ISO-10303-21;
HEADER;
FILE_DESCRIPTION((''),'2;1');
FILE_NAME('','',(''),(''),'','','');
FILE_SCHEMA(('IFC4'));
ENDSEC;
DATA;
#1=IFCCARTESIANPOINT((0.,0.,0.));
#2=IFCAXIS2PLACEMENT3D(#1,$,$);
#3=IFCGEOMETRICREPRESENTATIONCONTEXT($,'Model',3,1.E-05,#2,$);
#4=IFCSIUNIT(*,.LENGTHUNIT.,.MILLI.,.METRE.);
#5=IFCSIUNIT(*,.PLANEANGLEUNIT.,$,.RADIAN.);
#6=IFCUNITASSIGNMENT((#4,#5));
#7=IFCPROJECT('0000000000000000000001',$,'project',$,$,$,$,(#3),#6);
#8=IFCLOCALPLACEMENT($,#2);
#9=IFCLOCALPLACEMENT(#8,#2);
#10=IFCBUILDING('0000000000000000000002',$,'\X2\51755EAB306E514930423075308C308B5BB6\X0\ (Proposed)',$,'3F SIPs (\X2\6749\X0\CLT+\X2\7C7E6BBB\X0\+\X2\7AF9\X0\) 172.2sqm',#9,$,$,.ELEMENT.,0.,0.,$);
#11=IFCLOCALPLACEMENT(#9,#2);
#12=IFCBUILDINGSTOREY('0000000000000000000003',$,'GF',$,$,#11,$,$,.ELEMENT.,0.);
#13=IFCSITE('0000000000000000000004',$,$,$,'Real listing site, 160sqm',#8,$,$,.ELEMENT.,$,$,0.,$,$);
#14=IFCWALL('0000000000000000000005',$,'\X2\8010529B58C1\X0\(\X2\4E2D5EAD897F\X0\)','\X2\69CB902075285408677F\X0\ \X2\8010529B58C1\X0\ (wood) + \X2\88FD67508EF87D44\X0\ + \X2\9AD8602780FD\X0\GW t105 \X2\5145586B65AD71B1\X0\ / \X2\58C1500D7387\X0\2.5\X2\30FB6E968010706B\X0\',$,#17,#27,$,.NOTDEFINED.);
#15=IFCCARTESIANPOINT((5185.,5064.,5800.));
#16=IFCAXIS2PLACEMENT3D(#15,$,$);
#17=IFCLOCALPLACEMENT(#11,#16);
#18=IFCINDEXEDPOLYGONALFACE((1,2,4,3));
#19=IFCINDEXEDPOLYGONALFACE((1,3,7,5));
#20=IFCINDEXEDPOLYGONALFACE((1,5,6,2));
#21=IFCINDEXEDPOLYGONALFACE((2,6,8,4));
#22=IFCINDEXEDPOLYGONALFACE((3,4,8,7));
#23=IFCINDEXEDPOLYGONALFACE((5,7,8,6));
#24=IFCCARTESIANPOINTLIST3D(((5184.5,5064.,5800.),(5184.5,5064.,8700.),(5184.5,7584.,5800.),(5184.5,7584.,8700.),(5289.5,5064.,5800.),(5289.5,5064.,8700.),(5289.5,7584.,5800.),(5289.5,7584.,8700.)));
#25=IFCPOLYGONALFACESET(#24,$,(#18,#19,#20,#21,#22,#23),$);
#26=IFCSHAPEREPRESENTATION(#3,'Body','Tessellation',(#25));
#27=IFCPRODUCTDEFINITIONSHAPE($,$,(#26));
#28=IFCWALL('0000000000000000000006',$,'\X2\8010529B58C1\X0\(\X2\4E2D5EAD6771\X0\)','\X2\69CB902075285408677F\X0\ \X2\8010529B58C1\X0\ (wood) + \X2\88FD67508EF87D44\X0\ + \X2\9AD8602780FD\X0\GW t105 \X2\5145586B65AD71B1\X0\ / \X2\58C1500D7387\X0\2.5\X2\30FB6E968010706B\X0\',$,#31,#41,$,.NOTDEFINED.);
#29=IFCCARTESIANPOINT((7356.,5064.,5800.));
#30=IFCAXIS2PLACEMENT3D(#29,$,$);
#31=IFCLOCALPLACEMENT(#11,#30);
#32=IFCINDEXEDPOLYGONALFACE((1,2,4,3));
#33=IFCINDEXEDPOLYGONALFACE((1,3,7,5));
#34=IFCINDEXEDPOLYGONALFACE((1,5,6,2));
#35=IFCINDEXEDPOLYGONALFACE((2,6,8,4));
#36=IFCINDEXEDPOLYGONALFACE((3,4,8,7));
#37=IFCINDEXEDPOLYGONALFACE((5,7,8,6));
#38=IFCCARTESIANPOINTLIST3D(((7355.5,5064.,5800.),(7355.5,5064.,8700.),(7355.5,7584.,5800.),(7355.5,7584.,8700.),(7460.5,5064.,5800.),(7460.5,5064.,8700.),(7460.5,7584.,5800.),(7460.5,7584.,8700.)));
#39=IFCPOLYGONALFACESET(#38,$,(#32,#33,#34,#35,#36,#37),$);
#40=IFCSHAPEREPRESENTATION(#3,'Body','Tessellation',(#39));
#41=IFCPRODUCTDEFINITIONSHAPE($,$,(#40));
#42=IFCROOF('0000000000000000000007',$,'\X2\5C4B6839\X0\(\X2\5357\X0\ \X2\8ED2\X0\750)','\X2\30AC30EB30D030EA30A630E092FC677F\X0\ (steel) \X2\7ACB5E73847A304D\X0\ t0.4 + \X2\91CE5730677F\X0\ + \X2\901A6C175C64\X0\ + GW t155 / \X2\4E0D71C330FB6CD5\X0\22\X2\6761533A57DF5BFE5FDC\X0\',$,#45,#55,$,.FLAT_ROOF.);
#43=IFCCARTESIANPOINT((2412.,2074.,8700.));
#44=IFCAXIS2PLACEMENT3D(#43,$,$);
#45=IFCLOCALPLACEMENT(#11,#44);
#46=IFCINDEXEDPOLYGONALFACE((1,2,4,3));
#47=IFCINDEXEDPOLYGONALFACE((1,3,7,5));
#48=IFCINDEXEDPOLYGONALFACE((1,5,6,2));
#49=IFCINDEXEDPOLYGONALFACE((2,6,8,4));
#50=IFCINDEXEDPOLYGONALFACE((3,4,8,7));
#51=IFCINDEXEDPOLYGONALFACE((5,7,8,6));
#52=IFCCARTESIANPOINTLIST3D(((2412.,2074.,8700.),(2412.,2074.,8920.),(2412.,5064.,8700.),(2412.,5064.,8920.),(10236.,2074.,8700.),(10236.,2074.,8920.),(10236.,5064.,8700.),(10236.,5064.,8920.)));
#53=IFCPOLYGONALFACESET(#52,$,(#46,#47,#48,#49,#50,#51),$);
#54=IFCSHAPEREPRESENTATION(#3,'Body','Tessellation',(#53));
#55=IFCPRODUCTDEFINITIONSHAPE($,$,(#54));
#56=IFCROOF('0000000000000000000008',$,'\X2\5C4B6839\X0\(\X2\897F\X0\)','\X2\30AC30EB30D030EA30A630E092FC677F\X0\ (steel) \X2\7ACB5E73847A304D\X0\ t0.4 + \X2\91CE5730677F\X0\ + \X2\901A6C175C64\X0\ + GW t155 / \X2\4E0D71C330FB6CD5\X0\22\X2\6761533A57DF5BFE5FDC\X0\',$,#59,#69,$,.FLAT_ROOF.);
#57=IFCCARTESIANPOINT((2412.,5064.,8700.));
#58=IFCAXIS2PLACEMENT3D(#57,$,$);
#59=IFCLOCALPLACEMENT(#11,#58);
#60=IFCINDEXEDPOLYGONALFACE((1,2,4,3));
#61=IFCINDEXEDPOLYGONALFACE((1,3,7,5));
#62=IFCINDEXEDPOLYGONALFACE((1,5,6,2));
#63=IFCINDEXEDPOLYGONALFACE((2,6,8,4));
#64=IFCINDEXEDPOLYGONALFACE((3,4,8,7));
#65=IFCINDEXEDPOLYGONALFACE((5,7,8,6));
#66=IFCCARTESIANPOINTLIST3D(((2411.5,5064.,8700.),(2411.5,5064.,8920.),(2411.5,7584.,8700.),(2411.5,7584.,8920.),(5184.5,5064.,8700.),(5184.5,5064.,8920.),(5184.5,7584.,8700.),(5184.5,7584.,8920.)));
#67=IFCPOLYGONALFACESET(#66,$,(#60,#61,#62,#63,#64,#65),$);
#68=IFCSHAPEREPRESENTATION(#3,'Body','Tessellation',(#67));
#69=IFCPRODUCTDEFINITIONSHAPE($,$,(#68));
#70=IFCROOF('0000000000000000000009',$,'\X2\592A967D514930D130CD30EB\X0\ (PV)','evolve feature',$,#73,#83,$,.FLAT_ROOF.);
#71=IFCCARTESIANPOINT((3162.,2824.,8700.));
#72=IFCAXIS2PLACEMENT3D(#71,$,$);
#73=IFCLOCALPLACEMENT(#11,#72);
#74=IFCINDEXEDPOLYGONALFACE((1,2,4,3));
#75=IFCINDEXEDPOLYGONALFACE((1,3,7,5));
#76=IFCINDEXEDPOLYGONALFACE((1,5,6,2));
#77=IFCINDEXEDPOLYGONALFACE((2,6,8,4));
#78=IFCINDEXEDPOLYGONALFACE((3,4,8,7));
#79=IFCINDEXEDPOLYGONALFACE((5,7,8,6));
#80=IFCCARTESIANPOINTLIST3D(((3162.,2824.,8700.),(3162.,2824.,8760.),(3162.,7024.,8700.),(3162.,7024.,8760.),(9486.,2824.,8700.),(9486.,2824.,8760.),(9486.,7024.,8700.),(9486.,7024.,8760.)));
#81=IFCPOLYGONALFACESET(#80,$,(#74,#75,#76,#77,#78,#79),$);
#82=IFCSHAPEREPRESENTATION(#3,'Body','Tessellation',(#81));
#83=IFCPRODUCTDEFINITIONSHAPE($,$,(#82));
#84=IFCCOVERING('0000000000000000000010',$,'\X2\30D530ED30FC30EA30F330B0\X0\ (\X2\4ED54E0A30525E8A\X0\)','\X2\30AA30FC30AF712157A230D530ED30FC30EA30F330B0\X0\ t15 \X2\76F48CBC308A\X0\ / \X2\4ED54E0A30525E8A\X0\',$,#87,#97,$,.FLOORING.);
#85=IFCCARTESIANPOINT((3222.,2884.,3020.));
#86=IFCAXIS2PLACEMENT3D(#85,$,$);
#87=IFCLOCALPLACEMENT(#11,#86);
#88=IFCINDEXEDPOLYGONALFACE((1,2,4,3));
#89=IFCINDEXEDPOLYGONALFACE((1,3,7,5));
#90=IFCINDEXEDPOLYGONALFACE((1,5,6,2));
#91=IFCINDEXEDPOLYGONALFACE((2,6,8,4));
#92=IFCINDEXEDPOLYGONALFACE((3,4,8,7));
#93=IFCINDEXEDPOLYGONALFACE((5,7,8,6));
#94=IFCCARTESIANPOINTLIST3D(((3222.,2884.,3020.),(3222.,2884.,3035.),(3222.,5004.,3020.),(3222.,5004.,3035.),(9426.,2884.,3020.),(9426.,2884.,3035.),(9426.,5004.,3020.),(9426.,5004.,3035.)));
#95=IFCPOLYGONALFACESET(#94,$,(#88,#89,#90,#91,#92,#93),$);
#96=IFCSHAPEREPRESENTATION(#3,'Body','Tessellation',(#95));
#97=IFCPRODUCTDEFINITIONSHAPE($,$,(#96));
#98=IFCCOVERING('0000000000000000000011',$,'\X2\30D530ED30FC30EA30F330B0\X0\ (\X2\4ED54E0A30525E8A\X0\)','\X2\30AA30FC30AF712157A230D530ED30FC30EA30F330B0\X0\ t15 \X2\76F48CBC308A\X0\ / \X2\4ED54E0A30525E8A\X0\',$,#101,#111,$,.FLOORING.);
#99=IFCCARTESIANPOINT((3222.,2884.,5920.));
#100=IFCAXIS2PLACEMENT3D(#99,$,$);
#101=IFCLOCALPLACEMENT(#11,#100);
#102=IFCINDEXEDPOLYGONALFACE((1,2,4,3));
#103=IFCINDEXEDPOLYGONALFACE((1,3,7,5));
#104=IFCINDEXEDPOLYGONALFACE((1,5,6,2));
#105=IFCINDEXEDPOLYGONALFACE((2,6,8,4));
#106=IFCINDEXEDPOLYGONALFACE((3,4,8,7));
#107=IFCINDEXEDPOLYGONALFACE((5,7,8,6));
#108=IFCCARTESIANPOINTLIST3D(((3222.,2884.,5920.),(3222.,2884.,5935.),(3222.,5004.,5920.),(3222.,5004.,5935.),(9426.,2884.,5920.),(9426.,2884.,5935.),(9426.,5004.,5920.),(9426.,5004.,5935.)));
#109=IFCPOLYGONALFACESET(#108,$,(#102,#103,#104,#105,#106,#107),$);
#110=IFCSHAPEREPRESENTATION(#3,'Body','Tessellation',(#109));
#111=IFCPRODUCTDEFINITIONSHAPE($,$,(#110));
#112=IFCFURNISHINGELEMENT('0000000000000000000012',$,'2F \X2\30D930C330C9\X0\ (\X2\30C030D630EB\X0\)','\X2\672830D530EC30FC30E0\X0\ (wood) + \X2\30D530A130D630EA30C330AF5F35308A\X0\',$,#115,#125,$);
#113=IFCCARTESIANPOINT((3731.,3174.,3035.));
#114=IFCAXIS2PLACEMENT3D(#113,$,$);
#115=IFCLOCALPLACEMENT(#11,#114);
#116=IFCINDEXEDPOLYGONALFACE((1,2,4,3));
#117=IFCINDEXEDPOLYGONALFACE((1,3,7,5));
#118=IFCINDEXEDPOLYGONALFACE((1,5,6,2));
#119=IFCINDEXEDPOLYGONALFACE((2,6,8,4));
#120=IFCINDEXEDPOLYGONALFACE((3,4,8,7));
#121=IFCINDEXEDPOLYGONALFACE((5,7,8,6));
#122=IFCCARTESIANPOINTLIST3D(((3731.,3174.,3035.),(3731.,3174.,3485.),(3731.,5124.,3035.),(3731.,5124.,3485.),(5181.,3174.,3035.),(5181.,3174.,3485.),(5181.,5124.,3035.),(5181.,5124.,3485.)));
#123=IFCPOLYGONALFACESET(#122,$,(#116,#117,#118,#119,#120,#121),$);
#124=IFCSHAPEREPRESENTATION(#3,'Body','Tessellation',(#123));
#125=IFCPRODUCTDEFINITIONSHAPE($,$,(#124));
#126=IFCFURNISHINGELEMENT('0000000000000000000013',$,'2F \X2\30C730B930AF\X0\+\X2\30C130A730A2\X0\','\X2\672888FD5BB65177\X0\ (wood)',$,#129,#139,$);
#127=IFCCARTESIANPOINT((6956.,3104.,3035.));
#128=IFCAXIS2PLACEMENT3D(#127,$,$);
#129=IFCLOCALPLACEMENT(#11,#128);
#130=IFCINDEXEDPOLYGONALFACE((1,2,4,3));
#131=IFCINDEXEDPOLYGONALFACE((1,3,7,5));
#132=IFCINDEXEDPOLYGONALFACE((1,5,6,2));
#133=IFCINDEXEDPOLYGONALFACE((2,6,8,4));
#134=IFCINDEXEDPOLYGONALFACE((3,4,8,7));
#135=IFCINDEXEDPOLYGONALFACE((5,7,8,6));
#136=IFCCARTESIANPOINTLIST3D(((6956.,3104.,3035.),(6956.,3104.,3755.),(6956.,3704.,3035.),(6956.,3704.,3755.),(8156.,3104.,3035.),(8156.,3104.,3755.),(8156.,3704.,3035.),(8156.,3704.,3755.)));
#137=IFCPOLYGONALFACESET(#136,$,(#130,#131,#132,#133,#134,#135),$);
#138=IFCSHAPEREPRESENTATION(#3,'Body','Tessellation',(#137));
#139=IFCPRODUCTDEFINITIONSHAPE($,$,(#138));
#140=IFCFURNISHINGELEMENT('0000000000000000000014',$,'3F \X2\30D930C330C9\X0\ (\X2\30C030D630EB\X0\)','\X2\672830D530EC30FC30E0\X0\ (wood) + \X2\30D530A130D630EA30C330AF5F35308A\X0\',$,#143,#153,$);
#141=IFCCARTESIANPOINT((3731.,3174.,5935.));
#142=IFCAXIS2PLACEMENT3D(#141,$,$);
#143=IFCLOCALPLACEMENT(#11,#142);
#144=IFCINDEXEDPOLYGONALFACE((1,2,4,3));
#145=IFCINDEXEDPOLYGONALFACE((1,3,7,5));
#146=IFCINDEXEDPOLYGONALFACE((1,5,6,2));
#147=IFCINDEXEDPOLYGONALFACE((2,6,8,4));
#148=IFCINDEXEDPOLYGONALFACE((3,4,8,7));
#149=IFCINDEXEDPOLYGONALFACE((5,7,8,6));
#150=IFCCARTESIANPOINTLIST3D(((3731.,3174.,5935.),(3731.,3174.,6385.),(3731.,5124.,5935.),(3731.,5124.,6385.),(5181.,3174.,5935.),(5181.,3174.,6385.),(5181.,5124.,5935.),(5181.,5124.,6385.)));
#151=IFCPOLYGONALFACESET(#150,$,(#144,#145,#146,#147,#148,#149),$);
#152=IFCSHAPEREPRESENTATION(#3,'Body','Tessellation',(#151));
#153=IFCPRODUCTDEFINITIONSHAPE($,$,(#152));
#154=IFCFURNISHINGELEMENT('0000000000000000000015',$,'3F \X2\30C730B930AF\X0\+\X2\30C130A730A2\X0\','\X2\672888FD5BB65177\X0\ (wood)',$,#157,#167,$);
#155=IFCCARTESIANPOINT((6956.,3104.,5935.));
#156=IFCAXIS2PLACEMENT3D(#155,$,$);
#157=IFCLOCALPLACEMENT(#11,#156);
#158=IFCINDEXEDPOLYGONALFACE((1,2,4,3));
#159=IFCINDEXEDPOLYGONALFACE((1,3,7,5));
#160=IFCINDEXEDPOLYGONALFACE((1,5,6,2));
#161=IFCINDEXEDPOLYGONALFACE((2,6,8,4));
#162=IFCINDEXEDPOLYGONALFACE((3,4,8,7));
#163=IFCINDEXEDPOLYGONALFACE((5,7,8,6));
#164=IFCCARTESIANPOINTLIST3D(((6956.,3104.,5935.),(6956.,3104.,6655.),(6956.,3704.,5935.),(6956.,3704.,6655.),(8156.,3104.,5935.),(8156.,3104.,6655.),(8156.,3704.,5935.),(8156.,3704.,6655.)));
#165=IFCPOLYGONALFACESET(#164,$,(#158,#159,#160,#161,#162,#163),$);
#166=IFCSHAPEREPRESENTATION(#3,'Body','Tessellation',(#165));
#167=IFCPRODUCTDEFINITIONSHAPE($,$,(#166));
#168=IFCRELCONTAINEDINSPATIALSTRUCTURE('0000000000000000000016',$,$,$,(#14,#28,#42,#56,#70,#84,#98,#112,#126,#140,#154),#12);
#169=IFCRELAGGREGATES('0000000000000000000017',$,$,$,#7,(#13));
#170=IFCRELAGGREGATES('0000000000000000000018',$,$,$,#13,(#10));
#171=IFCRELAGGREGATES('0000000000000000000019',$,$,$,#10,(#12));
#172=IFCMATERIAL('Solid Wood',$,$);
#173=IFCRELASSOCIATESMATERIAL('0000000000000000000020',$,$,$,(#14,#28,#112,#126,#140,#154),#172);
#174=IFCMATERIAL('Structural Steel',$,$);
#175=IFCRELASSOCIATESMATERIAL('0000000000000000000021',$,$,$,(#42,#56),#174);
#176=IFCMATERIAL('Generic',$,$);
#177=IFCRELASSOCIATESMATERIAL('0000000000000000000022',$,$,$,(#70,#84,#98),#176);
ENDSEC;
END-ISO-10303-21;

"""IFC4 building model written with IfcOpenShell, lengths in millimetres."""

from ifc_helpers import new_model, si_unit, frame, frame_2d, origin, place, context, project, spatial, rectangle, extrude, material, element, save


model = new_model("IFC4")

# Units and contexts
model_context = context("Model", 3, precision=1e-05, world=origin())
ifc_project = project(units=[si_unit("LENGTHUNIT", "METRE", prefix="MILLI"), si_unit("PLANEANGLEUNIT", "RADIAN")], contexts=[model_context])

# Site, building, storey
site_placement = place(None, origin())
site = spatial("IfcSite", under=ifc_project, at=site_placement, ObjectType="Real listing site, 160sqm", CompositionType="ELEMENT", RefElevation=0.0)
building_placement = place(site_placement, origin())
building = spatial("IfcBuilding", under=site, at=building_placement, Name="兵庫の光あふれる家 (Proposed)", ObjectType="3F SIPs (杉CLT+籾殻+竹) 172.2sqm", CompositionType="ELEMENT", ElevationOfRefHeight=0.0, ElevationOfTerrain=0.0)
storey_placement = place(building_placement, origin())
storey = spatial("IfcBuildingStorey", under=building, at=storey_placement, Name="GF", CompositionType="ELEMENT", Elevation=0.0)

# Shared definitions
ifc_material_1 = material(Name="Solid Wood")

# Walls
wall_1_placement = place(storey_placement, frame((5185.0, 5064.0, 5800.0)))
element("IfcWall", 1, at=wall_1_placement, inside=storey, material=ifc_material_1, Name="耐力壁(中庭西)", Description="構造用合板 耐力壁 (wood) + 製材軸組 + 高性能GW t105 充填断熱 / 壁倍率2.5・準耐火", PredefinedType="NOTDEFINED", context=model_context, shape_type="SweptSolid", body=[
    extrude(rectangle(XDim=105.0, YDim=2520.0, at=frame_2d((52.0, 1260.0))), frame((5185.0, 5064.0, 5800.0)), (0.0, 0.0, 1.0), 2900.0),
])
wall_2_placement = place(storey_placement, frame((7356.0, 5064.0, 5800.0)))
element("IfcWall", 2, at=wall_2_placement, inside=storey, material=ifc_material_1, Name="耐力壁(中庭東)", Description="構造用合板 耐力壁 (wood) + 製材軸組 + 高性能GW t105 充填断熱 / 壁倍率2.5・準耐火", PredefinedType="NOTDEFINED", context=model_context, shape_type="SweptSolid", body=[
    extrude(rectangle(XDim=105.0, YDim=2520.0, at=frame_2d((52.0, 1260.0))), frame((7356.0, 5064.0, 5800.0)), (0.0, 0.0, 1.0), 2900.0),
])

# Roofs
ifc_material_2 = material(Name="Structural Steel")
roof_1_placement = place(storey_placement, frame((2412.0, 2074.0, 8700.0)))
element("IfcRoof", 3, at=roof_1_placement, inside=storey, material=ifc_material_2, Name="屋根(南 軒750)", Description="ガルバリウム鋼板 (steel) 立平葺き t0.4 + 野地板 + 通気層 + GW t155 / 不燃・法22条区域対応", PredefinedType="FLAT_ROOF", context=model_context, shape_type="SweptSolid", body=[
    extrude(rectangle(XDim=7824.0, YDim=2990.0, at=frame_2d((3912.0, 1495.0))), frame((2412.0, 2074.0, 8700.0)), (0.0, 0.0, 1.0), 220.0),
])
roof_2_placement = place(storey_placement, frame((2412.0, 5064.0, 8700.0)))
element("IfcRoof", 4, at=roof_2_placement, inside=storey, material=ifc_material_2, Name="屋根(西)", Description="ガルバリウム鋼板 (steel) 立平葺き t0.4 + 野地板 + 通気層 + GW t155 / 不燃・法22条区域対応", PredefinedType="FLAT_ROOF", context=model_context, shape_type="SweptSolid", body=[
    extrude(rectangle(XDim=2773.0, YDim=2520.0, at=frame_2d((1386.0, 1260.0))), frame((2412.0, 5064.0, 8700.0)), (0.0, 0.0, 1.0), 220.0),
])
ifc_material_3 = material(Name="Generic")
roof_3_placement = place(storey_placement, frame((3162.0, 2824.0, 8700.0)))
element("IfcRoof", 5, at=roof_3_placement, inside=storey, material=ifc_material_3, Name="太陽光パネル (PV)", Description="evolve feature", PredefinedType="FLAT_ROOF", context=model_context, shape_type="SweptSolid", body=[
    extrude(rectangle(XDim=6324.0, YDim=4200.0, at=frame_2d((3162.0, 2100.0))), frame((3162.0, 2824.0, 8700.0)), (0.0, 0.0, 1.0), 60.0),
])

# Coverings
covering_1_placement = place(storey_placement, frame((3222.0, 2884.0, 3020.0)))
element("IfcCovering", 6, at=covering_1_placement, inside=storey, material=ifc_material_3, Name="フローリング (仕上げ床)", Description="オーク無垢フローリング t15 直貼り / 仕上げ床", PredefinedType="FLOORING", context=model_context, shape_type="SweptSolid", body=[
    extrude(rectangle(XDim=6204.0, YDim=2120.0, at=frame_2d((3102.0, 1060.0))), frame((3222.0, 2884.0, 3020.0)), (0.0, 0.0, 1.0), 15.0),
])
covering_2_placement = place(storey_placement, frame((3222.0, 2884.0, 5920.0)))
element("IfcCovering", 7, at=covering_2_placement, inside=storey, material=ifc_material_3, Name="フローリング (仕上げ床)", Description="オーク無垢フローリング t15 直貼り / 仕上げ床", PredefinedType="FLOORING", context=model_context, shape_type="SweptSolid", body=[
    extrude(rectangle(XDim=6204.0, YDim=2120.0, at=frame_2d((3102.0, 1060.0))), frame((3222.0, 2884.0, 5920.0)), (0.0, 0.0, 1.0), 15.0),
])

# Furnishing elements
furnishing_1_placement = place(storey_placement, frame((3731.0, 3174.0, 3035.0)))
element("IfcFurnishingElement", 8, at=furnishing_1_placement, inside=storey, material=ifc_material_1, Name="2F ベッド (ダブル)", Description="木フレーム (wood) + ファブリック張り", context=model_context, shape_type="SweptSolid", body=[
    extrude(rectangle(XDim=1450.0, YDim=1950.0, at=frame_2d((725.0, 975.0))), frame((3731.0, 3174.0, 3035.0)), (0.0, 0.0, 1.0), 450.0),
])
furnishing_2_placement = place(storey_placement, frame((6956.0, 3104.0, 3035.0)))
element("IfcFurnishingElement", 9, at=furnishing_2_placement, inside=storey, material=ifc_material_1, Name="2F デスク+チェア", Description="木製家具 (wood)", context=model_context, shape_type="SweptSolid", body=[
    extrude(rectangle(XDim=1200.0, YDim=600.0, at=frame_2d((600.0, 300.0))), frame((6956.0, 3104.0, 3035.0)), (0.0, 0.0, 1.0), 720.0),
])
furnishing_3_placement = place(storey_placement, frame((3731.0, 3174.0, 5935.0)))
element("IfcFurnishingElement", 10, at=furnishing_3_placement, inside=storey, material=ifc_material_1, Name="3F ベッド (ダブル)", Description="木フレーム (wood) + ファブリック張り", context=model_context, shape_type="SweptSolid", body=[
    extrude(rectangle(XDim=1450.0, YDim=1950.0, at=frame_2d((725.0, 975.0))), frame((3731.0, 3174.0, 5935.0)), (0.0, 0.0, 1.0), 450.0),
])
furnishing_4_placement = place(storey_placement, frame((6956.0, 3104.0, 5935.0)))
element("IfcFurnishingElement", 11, at=furnishing_4_placement, inside=storey, material=ifc_material_1, Name="3F デスク+チェア", Description="木製家具 (wood)", context=model_context, shape_type="SweptSolid", body=[
    extrude(rectangle(XDim=1200.0, YDim=600.0, at=frame_2d((600.0, 300.0))), frame((6956.0, 3104.0, 5935.0)), (0.0, 0.0, 1.0), 720.0),
])

save(model, "model.ifc")
